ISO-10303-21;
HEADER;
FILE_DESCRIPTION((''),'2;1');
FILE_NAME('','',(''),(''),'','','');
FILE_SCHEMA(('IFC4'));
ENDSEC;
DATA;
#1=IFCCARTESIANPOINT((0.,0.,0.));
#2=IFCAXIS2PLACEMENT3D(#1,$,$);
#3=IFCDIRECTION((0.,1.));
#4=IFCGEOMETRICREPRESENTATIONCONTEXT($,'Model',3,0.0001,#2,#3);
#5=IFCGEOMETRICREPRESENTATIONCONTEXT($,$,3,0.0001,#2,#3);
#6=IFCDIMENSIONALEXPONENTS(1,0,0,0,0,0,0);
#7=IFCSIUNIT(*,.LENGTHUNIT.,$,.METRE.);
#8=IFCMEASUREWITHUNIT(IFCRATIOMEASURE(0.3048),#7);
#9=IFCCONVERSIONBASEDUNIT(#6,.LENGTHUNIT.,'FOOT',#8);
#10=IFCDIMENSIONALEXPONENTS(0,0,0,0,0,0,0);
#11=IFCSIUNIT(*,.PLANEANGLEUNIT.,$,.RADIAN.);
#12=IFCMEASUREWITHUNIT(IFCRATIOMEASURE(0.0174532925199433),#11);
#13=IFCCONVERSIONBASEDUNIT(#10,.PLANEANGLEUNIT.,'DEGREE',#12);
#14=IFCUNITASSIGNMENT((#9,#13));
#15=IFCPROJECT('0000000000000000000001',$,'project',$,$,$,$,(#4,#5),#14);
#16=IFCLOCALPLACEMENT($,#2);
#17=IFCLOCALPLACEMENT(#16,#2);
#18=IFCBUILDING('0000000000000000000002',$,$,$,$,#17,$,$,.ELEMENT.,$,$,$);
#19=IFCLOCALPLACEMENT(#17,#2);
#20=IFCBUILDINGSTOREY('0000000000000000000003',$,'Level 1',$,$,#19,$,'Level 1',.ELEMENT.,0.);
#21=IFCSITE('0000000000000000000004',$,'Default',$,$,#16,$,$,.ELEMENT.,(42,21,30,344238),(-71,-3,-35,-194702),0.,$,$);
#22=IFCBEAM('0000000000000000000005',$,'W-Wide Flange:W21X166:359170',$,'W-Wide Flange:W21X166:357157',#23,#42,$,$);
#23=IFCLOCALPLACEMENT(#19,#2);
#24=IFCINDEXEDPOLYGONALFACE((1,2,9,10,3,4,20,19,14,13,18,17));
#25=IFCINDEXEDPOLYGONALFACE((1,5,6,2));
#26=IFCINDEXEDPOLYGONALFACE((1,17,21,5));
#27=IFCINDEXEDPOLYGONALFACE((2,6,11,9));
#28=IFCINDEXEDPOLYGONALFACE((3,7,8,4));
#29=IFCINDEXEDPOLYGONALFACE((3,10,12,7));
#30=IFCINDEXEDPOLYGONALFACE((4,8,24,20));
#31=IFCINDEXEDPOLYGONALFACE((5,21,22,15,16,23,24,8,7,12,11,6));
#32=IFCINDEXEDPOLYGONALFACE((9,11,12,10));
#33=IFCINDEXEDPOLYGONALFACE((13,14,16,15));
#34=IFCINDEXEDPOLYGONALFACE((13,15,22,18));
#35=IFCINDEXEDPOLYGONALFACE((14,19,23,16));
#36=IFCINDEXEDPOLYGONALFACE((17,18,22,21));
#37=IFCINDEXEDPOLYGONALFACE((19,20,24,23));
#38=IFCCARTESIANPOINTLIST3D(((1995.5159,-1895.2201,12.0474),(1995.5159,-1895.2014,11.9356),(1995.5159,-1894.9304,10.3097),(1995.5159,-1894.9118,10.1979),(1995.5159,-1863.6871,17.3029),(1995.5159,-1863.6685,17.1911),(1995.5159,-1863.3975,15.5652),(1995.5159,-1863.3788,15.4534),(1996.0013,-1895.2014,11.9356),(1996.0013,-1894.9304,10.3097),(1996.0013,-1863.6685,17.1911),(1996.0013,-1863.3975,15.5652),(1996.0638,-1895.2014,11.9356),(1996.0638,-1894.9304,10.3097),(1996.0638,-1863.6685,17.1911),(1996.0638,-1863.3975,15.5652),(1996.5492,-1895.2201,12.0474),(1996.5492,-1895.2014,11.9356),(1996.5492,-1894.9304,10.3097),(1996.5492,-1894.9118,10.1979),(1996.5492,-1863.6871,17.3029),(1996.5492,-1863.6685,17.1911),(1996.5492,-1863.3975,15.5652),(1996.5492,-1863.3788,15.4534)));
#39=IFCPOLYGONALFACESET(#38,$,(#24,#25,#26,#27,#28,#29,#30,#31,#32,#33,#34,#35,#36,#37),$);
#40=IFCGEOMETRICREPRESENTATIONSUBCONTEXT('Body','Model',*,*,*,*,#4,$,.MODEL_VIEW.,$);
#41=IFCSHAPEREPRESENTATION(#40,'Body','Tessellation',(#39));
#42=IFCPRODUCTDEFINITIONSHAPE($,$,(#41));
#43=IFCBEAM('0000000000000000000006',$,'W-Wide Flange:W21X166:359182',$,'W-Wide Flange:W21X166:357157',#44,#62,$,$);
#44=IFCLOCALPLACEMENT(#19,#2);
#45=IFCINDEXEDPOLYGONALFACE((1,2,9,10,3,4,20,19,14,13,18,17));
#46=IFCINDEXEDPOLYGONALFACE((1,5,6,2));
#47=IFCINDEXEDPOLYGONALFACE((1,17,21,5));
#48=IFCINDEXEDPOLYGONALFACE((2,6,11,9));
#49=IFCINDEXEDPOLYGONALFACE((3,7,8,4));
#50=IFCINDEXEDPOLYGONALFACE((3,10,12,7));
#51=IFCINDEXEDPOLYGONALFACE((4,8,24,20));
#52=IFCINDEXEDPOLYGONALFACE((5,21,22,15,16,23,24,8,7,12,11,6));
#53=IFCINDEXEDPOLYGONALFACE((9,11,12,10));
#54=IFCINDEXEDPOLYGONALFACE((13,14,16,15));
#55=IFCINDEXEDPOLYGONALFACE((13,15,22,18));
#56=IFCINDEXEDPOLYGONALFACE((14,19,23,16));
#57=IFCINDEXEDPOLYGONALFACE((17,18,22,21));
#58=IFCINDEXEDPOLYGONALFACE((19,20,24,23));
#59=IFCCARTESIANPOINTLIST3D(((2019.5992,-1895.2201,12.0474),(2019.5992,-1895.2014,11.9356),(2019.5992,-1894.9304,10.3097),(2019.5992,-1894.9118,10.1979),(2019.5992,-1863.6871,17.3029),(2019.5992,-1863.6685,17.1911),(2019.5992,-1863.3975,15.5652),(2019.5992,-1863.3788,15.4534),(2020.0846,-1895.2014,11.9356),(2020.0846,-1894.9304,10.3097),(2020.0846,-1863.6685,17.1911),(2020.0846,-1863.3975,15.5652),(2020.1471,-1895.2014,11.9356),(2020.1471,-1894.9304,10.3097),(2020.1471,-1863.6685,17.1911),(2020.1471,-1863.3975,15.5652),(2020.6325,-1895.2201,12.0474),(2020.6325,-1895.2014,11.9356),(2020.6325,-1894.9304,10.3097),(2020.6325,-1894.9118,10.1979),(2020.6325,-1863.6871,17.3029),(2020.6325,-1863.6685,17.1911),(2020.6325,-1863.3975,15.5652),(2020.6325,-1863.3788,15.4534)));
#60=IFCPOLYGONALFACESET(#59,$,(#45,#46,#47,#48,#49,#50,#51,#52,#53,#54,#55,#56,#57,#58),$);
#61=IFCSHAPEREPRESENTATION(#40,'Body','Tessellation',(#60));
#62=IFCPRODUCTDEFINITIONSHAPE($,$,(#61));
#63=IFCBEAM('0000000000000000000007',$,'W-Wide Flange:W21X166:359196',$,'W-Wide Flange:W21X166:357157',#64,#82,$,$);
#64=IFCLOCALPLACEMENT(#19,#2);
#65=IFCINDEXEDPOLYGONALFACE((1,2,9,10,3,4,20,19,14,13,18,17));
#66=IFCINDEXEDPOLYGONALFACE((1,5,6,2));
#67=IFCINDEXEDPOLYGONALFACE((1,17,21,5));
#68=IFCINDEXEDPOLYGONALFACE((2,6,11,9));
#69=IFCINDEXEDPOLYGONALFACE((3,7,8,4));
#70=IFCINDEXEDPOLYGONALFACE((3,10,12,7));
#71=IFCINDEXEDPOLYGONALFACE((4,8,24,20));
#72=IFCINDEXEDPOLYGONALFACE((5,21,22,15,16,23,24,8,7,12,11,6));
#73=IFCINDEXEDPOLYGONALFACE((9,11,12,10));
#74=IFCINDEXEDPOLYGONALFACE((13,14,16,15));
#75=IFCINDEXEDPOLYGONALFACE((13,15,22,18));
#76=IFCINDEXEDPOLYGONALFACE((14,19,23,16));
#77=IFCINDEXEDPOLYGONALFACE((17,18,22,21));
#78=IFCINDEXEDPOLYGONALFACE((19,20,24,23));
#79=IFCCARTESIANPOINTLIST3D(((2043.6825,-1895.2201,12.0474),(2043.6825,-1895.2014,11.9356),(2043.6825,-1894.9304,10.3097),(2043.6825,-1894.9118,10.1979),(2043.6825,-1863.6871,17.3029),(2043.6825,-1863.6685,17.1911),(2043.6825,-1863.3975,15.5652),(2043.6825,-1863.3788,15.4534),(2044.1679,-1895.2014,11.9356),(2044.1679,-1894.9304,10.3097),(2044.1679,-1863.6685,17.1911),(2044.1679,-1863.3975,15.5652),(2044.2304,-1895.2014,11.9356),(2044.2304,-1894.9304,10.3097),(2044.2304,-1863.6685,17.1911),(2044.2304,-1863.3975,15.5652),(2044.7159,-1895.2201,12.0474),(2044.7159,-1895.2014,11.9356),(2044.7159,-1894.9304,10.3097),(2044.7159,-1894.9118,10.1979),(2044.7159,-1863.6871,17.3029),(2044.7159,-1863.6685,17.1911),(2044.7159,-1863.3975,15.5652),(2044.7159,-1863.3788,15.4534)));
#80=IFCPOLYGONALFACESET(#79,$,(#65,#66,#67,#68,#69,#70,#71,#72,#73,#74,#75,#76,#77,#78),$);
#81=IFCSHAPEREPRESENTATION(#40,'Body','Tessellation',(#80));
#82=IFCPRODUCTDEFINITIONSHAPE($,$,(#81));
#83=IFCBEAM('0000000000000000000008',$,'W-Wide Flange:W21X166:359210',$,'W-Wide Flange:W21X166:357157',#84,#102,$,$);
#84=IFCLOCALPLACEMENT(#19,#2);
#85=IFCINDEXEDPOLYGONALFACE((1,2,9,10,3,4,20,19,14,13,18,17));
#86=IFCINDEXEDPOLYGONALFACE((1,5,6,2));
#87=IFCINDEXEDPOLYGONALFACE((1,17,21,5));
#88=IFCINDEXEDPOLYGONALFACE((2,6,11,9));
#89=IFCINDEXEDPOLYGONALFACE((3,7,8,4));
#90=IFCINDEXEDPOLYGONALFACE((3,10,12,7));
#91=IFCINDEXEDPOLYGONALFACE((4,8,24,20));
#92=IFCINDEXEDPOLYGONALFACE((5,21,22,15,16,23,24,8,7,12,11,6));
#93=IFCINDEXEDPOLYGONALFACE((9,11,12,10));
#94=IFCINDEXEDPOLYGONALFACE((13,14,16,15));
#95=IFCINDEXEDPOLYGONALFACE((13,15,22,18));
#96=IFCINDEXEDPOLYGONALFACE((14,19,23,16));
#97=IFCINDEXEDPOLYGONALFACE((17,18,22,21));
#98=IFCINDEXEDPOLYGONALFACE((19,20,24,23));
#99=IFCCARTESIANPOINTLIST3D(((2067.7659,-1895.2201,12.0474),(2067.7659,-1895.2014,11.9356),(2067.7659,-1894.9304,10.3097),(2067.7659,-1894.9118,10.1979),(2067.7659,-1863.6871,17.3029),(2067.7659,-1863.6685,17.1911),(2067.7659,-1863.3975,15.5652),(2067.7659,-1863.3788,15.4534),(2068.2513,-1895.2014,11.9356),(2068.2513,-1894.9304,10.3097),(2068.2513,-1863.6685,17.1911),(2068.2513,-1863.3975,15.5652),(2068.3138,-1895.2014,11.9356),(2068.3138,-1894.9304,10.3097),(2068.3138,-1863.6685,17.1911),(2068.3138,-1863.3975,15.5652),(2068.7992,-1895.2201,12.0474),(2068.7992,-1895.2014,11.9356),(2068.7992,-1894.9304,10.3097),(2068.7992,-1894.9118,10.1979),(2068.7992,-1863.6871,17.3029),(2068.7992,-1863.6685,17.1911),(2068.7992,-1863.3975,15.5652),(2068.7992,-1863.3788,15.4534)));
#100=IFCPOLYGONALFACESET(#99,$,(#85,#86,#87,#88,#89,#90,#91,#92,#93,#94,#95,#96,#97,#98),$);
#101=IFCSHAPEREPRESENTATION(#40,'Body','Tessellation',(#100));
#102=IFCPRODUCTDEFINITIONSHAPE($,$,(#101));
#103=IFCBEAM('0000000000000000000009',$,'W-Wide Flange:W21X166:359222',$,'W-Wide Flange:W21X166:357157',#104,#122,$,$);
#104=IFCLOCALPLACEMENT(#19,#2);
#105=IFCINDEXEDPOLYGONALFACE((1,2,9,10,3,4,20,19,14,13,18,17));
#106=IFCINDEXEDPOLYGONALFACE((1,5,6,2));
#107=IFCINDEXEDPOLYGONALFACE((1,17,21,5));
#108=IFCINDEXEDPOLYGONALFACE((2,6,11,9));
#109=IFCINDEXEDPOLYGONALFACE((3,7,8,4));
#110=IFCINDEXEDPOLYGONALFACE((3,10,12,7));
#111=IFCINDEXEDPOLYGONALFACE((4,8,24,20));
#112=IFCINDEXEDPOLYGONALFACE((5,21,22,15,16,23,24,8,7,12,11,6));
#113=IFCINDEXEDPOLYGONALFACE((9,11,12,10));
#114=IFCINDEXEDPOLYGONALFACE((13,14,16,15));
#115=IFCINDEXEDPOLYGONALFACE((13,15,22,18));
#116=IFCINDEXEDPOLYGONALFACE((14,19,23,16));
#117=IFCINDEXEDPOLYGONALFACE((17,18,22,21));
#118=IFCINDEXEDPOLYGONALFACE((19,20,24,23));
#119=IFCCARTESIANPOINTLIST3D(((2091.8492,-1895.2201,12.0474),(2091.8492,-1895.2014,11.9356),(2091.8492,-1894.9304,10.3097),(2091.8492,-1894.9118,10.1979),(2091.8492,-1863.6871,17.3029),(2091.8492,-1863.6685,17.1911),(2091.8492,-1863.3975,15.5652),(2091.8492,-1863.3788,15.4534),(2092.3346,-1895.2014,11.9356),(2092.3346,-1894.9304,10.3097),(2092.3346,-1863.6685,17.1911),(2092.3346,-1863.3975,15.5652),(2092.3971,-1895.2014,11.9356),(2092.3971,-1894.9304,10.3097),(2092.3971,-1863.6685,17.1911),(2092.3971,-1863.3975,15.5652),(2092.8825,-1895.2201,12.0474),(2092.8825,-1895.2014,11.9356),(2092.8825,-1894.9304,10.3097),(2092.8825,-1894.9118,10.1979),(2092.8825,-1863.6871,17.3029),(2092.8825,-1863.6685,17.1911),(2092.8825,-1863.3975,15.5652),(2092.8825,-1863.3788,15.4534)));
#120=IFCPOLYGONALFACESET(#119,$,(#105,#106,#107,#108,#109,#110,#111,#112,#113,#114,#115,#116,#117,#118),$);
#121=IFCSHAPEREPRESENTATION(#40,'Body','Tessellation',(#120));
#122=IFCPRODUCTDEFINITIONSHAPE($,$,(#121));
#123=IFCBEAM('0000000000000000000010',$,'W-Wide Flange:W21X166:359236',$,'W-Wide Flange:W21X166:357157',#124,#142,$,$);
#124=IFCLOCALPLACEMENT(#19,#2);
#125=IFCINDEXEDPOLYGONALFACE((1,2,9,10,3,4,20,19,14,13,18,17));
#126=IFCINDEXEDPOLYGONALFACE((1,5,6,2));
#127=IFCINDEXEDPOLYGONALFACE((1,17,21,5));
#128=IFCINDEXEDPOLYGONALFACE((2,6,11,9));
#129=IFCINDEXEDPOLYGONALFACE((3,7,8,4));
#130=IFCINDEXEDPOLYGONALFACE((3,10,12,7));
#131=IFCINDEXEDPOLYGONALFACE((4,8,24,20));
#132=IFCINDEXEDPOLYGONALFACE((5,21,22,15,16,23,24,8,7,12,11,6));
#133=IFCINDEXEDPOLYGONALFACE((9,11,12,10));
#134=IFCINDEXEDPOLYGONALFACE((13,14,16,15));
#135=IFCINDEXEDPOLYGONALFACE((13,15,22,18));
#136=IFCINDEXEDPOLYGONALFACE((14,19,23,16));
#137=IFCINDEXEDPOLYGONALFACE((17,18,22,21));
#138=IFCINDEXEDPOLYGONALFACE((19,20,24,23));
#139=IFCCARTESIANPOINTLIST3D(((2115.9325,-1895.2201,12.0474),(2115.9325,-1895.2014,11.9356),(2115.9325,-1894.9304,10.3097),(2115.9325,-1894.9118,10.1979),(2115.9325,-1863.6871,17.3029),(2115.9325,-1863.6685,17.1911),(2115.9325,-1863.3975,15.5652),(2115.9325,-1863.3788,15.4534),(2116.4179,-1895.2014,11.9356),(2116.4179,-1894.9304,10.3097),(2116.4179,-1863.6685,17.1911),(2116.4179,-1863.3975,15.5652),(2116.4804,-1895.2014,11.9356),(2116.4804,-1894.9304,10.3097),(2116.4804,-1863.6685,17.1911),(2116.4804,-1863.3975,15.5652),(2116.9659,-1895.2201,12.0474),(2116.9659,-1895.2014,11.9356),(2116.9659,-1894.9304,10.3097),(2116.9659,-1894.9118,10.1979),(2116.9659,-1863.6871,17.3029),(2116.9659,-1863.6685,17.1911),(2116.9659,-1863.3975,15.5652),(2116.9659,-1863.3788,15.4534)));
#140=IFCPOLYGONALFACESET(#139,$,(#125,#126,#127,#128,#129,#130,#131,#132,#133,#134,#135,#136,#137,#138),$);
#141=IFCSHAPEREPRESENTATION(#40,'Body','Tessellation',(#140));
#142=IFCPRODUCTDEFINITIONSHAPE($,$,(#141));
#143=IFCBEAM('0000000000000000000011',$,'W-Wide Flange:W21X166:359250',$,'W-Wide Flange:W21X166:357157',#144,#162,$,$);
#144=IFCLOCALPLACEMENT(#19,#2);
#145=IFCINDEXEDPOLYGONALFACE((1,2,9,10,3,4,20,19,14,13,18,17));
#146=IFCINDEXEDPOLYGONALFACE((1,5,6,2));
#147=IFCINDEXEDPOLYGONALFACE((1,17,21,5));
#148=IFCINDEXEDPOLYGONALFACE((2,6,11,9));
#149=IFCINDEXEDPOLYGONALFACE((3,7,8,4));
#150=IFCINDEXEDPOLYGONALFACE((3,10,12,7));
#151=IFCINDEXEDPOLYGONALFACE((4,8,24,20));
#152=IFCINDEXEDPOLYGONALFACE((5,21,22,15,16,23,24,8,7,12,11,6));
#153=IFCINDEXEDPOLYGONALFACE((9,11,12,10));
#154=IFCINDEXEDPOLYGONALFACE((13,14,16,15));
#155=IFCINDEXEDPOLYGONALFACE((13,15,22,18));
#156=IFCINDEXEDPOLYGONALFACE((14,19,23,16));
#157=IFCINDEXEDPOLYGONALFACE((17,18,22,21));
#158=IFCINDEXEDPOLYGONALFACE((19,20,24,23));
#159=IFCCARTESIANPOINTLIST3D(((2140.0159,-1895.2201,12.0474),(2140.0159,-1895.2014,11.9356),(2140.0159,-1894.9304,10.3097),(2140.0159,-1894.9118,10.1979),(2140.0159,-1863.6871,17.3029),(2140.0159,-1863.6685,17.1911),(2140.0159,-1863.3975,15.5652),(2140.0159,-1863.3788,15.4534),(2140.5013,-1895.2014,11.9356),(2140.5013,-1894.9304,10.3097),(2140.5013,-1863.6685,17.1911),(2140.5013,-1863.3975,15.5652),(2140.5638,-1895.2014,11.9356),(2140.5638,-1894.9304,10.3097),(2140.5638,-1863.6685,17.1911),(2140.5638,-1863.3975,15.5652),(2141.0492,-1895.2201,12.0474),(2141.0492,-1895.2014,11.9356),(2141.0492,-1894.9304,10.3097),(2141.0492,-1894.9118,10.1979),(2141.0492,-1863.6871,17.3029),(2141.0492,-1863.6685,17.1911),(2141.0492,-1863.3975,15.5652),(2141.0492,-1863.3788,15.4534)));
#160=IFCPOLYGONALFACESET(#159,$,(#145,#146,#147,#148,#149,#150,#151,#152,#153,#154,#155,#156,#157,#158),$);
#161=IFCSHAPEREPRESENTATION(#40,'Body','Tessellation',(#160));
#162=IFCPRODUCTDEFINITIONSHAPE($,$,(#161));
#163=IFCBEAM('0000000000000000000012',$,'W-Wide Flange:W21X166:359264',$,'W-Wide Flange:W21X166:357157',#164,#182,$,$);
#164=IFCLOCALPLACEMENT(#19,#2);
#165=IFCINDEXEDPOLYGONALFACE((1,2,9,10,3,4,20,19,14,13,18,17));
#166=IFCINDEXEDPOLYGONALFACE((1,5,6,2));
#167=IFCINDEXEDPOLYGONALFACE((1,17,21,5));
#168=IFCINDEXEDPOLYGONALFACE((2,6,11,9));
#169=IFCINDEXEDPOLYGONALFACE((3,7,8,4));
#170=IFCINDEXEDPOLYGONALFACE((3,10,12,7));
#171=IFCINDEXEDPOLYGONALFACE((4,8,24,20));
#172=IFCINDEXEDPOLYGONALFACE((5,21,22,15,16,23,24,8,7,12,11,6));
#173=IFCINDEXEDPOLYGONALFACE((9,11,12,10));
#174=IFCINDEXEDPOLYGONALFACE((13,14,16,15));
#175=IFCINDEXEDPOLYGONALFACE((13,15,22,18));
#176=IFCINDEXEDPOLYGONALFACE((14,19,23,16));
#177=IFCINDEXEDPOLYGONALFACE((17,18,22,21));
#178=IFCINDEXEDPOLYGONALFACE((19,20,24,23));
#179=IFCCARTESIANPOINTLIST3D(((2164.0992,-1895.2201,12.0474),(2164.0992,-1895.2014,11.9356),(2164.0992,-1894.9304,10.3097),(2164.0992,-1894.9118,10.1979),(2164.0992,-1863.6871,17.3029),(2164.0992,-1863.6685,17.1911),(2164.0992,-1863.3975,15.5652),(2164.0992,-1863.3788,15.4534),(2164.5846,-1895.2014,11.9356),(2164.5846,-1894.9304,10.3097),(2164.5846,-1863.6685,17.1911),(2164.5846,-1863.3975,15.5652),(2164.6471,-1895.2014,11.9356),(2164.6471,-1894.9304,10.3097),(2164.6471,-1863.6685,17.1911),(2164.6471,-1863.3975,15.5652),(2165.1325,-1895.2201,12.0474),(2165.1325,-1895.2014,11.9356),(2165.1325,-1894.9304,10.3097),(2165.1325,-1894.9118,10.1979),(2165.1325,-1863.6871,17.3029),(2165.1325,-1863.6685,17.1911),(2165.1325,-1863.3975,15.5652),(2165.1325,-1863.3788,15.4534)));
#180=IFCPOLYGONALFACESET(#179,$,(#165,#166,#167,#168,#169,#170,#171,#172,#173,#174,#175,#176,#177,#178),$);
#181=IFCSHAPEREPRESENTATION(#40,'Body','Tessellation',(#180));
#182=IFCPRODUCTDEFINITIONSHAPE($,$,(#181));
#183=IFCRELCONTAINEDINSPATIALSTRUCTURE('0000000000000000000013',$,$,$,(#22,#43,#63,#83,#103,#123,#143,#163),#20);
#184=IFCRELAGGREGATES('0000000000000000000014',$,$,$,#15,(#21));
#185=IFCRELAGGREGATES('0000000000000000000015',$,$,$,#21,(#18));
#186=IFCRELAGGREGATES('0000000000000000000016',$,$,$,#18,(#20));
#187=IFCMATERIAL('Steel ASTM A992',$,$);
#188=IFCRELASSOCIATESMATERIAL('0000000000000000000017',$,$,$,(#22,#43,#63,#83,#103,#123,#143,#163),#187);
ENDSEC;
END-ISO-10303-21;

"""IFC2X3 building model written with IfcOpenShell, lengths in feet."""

from ifc_helpers import new_model, entity, si_unit, converted_unit, direction, frame, frame_2d, origin, place, context, subcontext, project, spatial, i_section, extrude, material, element, save


model = new_model("IFC2X3")

# Units and contexts
model_context = context("Model", 3, precision=0.0001, world=origin(), true_north=direction((0.0, 1.0)))
context_of_model = context(None, 3, precision=0.0001, world=origin(), true_north=direction((0.0, 1.0)))
body_context = subcontext(model_context, "Body", "Model", "MODEL_VIEW")
ifc_project = project(units=[converted_unit("LENGTHUNIT", "FOOT", entity("IfcRatioMeasure", 0.3048), si_unit("LENGTHUNIT", "METRE"), dimensions=[1, 0, 0, 0, 0, 0, 0]), converted_unit("PLANEANGLEUNIT", "DEGREE", entity("IfcRatioMeasure", 0.0174532925199433), si_unit("PLANEANGLEUNIT", "RADIAN"), dimensions=[0, 0, 0, 0, 0, 0, 0])], contexts=[model_context, context_of_model])

# Site, building, storey
site_placement = place(None, origin())
site = spatial("IfcSite", under=ifc_project, at=site_placement, Name="Default", CompositionType="ELEMENT", RefLatitude=(42, 21, 30, 344238), RefLongitude=(-71, -3, -35, -194702), RefElevation=0.0)
building_placement = place(site_placement, origin())
building = spatial("IfcBuilding", under=site, at=building_placement, CompositionType="ELEMENT")
storey_placement = place(building_placement, origin())
storey = spatial("IfcBuildingStorey", under=building, at=storey_placement, Name="Level 1", LongName="Level 1", CompositionType="ELEMENT", Elevation=0.0)

# Shared definitions
ifc_material_1 = material(Name="Steel ASTM A992")

# Beams
beam_1_placement = place(storey_placement, frame((1996.0325, -1895.6585, 11.9743), z_axis=(0.0, -0.164399, 0.986394), x_axis=(0.0, 0.986394, 0.164399)))
element("IfcBeam", 1, at=beam_1_placement, inside=storey, material=ifc_material_1, Name="W-Wide Flange:W21X166:359170", ObjectType="W-Wide Flange:W21X166:357157", context=body_context, shape_type="SweptSolid", body=[
    extrude(i_section(OverallWidth=1.0333, OverallDepth=1.875, WebThickness=0.0625, FlangeThickness=0.1133, at=frame_2d((0.0, 0.0), x_axis=(0.0, 1.0))), frame((0.4445, 0.0, -0.9375), z_axis=(1.0, 0.0, 0.0), x_axis=(0.0, 0.0, -1.0)), (0.0, 0.0, 1.0), 31.9679),
])
beam_2_placement = place(storey_placement, frame((2020.1159, -1895.6585, 11.9743), z_axis=(0.0, -0.164399, 0.986394), x_axis=(0.0, 0.986394, 0.164399)))
element("IfcBeam", 2, at=beam_2_placement, inside=storey, material=ifc_material_1, Name="W-Wide Flange:W21X166:359182", ObjectType="W-Wide Flange:W21X166:357157", context=body_context, shape_type="SweptSolid", body=[
    extrude(i_section(OverallWidth=1.0333, OverallDepth=1.875, WebThickness=0.0625, FlangeThickness=0.1133, at=frame_2d((0.0, 0.0), x_axis=(0.0, 1.0))), frame((0.4445, 0.0, -0.9375), z_axis=(1.0, 0.0, 0.0), x_axis=(0.0, 0.0, -1.0)), (0.0, 0.0, 1.0), 31.9679),
])
beam_3_placement = place(storey_placement, frame((2044.1992, -1895.6585, 11.9743), z_axis=(0.0, -0.164399, 0.986394), x_axis=(0.0, 0.986394, 0.164399)))
element("IfcBeam", 3, at=beam_3_placement, inside=storey, material=ifc_material_1, Name="W-Wide Flange:W21X166:359196", ObjectType="W-Wide Flange:W21X166:357157", context=body_context, shape_type="SweptSolid", body=[
    extrude(i_section(OverallWidth=1.0333, OverallDepth=1.875, WebThickness=0.0625, FlangeThickness=0.1133, at=frame_2d((0.0, 0.0), x_axis=(0.0, 1.0))), frame((0.4445, 0.0, -0.9375), z_axis=(1.0, 0.0, 0.0), x_axis=(0.0, 0.0, -1.0)), (0.0, 0.0, 1.0), 31.9679),
])
beam_4_placement = place(storey_placement, frame((2068.2825, -1895.6585, 11.9743), z_axis=(0.0, -0.164399, 0.986394), x_axis=(0.0, 0.986394, 0.164399)))
element("IfcBeam", 4, at=beam_4_placement, inside=storey, material=ifc_material_1, Name="W-Wide Flange:W21X166:359210", ObjectType="W-Wide Flange:W21X166:357157", context=body_context, shape_type="SweptSolid", body=[
    extrude(i_section(OverallWidth=1.0333, OverallDepth=1.875, WebThickness=0.0625, FlangeThickness=0.1133, at=frame_2d((0.0, 0.0), x_axis=(0.0, 1.0))), frame((0.4445, 0.0, -0.9375), z_axis=(1.0, 0.0, 0.0), x_axis=(0.0, 0.0, -1.0)), (0.0, 0.0, 1.0), 31.9679),
])
beam_5_placement = place(storey_placement, frame((2092.3659, -1895.6585, 11.9743), z_axis=(0.0, -0.164399, 0.986394), x_axis=(0.0, 0.986394, 0.164399)))
element("IfcBeam", 5, at=beam_5_placement, inside=storey, material=ifc_material_1, Name="W-Wide Flange:W21X166:359222", ObjectType="W-Wide Flange:W21X166:357157", context=body_context, shape_type="SweptSolid", body=[
    extrude(i_section(OverallWidth=1.0333, OverallDepth=1.875, WebThickness=0.0625, FlangeThickness=0.1133, at=frame_2d((0.0, 0.0), x_axis=(0.0, 1.0))), frame((0.4445, 0.0, -0.9375), z_axis=(1.0, 0.0, 0.0), x_axis=(0.0, 0.0, -1.0)), (0.0, 0.0, 1.0), 31.9679),
])
beam_6_placement = place(storey_placement, frame((2116.4492, -1895.6585, 11.9743), z_axis=(0.0, -0.164399, 0.986394), x_axis=(0.0, 0.986394, 0.164399)))
element("IfcBeam", 6, at=beam_6_placement, inside=storey, material=ifc_material_1, Name="W-Wide Flange:W21X166:359236", ObjectType="W-Wide Flange:W21X166:357157", context=body_context, shape_type="SweptSolid", body=[
    extrude(i_section(OverallWidth=1.0333, OverallDepth=1.875, WebThickness=0.0625, FlangeThickness=0.1133, at=frame_2d((0.0, 0.0), x_axis=(0.0, 1.0))), frame((0.4445, 0.0, -0.9375), z_axis=(1.0, 0.0, 0.0), x_axis=(0.0, 0.0, -1.0)), (0.0, 0.0, 1.0), 31.9679),
])
beam_7_placement = place(storey_placement, frame((2140.5325, -1895.6585, 11.9743), z_axis=(0.0, -0.164399, 0.986394), x_axis=(0.0, 0.986394, 0.164399)))
element("IfcBeam", 7, at=beam_7_placement, inside=storey, material=ifc_material_1, Name="W-Wide Flange:W21X166:359250", ObjectType="W-Wide Flange:W21X166:357157", context=body_context, shape_type="SweptSolid", body=[
    extrude(i_section(OverallWidth=1.0333, OverallDepth=1.875, WebThickness=0.0625, FlangeThickness=0.1133, at=frame_2d((0.0, 0.0), x_axis=(0.0, 1.0))), frame((0.4445, 0.0, -0.9375), z_axis=(1.0, 0.0, 0.0), x_axis=(0.0, 0.0, -1.0)), (0.0, 0.0, 1.0), 31.9679),
])
beam_8_placement = place(storey_placement, frame((2164.6159, -1895.6585, 11.9743), z_axis=(0.0, -0.164399, 0.986394), x_axis=(0.0, 0.986394, 0.164399)))
element("IfcBeam", 8, at=beam_8_placement, inside=storey, material=ifc_material_1, Name="W-Wide Flange:W21X166:359264", ObjectType="W-Wide Flange:W21X166:357157", context=body_context, shape_type="SweptSolid", body=[
    extrude(i_section(OverallWidth=1.0333, OverallDepth=1.875, WebThickness=0.0625, FlangeThickness=0.1133, at=frame_2d((0.0, 0.0), x_axis=(0.0, 1.0))), frame((0.4445, 0.0, -0.9375), z_axis=(1.0, 0.0, 0.0), x_axis=(0.0, 0.0, -1.0)), (0.0, 0.0, 1.0), 31.9679),
])

save(model, "model.ifc")
